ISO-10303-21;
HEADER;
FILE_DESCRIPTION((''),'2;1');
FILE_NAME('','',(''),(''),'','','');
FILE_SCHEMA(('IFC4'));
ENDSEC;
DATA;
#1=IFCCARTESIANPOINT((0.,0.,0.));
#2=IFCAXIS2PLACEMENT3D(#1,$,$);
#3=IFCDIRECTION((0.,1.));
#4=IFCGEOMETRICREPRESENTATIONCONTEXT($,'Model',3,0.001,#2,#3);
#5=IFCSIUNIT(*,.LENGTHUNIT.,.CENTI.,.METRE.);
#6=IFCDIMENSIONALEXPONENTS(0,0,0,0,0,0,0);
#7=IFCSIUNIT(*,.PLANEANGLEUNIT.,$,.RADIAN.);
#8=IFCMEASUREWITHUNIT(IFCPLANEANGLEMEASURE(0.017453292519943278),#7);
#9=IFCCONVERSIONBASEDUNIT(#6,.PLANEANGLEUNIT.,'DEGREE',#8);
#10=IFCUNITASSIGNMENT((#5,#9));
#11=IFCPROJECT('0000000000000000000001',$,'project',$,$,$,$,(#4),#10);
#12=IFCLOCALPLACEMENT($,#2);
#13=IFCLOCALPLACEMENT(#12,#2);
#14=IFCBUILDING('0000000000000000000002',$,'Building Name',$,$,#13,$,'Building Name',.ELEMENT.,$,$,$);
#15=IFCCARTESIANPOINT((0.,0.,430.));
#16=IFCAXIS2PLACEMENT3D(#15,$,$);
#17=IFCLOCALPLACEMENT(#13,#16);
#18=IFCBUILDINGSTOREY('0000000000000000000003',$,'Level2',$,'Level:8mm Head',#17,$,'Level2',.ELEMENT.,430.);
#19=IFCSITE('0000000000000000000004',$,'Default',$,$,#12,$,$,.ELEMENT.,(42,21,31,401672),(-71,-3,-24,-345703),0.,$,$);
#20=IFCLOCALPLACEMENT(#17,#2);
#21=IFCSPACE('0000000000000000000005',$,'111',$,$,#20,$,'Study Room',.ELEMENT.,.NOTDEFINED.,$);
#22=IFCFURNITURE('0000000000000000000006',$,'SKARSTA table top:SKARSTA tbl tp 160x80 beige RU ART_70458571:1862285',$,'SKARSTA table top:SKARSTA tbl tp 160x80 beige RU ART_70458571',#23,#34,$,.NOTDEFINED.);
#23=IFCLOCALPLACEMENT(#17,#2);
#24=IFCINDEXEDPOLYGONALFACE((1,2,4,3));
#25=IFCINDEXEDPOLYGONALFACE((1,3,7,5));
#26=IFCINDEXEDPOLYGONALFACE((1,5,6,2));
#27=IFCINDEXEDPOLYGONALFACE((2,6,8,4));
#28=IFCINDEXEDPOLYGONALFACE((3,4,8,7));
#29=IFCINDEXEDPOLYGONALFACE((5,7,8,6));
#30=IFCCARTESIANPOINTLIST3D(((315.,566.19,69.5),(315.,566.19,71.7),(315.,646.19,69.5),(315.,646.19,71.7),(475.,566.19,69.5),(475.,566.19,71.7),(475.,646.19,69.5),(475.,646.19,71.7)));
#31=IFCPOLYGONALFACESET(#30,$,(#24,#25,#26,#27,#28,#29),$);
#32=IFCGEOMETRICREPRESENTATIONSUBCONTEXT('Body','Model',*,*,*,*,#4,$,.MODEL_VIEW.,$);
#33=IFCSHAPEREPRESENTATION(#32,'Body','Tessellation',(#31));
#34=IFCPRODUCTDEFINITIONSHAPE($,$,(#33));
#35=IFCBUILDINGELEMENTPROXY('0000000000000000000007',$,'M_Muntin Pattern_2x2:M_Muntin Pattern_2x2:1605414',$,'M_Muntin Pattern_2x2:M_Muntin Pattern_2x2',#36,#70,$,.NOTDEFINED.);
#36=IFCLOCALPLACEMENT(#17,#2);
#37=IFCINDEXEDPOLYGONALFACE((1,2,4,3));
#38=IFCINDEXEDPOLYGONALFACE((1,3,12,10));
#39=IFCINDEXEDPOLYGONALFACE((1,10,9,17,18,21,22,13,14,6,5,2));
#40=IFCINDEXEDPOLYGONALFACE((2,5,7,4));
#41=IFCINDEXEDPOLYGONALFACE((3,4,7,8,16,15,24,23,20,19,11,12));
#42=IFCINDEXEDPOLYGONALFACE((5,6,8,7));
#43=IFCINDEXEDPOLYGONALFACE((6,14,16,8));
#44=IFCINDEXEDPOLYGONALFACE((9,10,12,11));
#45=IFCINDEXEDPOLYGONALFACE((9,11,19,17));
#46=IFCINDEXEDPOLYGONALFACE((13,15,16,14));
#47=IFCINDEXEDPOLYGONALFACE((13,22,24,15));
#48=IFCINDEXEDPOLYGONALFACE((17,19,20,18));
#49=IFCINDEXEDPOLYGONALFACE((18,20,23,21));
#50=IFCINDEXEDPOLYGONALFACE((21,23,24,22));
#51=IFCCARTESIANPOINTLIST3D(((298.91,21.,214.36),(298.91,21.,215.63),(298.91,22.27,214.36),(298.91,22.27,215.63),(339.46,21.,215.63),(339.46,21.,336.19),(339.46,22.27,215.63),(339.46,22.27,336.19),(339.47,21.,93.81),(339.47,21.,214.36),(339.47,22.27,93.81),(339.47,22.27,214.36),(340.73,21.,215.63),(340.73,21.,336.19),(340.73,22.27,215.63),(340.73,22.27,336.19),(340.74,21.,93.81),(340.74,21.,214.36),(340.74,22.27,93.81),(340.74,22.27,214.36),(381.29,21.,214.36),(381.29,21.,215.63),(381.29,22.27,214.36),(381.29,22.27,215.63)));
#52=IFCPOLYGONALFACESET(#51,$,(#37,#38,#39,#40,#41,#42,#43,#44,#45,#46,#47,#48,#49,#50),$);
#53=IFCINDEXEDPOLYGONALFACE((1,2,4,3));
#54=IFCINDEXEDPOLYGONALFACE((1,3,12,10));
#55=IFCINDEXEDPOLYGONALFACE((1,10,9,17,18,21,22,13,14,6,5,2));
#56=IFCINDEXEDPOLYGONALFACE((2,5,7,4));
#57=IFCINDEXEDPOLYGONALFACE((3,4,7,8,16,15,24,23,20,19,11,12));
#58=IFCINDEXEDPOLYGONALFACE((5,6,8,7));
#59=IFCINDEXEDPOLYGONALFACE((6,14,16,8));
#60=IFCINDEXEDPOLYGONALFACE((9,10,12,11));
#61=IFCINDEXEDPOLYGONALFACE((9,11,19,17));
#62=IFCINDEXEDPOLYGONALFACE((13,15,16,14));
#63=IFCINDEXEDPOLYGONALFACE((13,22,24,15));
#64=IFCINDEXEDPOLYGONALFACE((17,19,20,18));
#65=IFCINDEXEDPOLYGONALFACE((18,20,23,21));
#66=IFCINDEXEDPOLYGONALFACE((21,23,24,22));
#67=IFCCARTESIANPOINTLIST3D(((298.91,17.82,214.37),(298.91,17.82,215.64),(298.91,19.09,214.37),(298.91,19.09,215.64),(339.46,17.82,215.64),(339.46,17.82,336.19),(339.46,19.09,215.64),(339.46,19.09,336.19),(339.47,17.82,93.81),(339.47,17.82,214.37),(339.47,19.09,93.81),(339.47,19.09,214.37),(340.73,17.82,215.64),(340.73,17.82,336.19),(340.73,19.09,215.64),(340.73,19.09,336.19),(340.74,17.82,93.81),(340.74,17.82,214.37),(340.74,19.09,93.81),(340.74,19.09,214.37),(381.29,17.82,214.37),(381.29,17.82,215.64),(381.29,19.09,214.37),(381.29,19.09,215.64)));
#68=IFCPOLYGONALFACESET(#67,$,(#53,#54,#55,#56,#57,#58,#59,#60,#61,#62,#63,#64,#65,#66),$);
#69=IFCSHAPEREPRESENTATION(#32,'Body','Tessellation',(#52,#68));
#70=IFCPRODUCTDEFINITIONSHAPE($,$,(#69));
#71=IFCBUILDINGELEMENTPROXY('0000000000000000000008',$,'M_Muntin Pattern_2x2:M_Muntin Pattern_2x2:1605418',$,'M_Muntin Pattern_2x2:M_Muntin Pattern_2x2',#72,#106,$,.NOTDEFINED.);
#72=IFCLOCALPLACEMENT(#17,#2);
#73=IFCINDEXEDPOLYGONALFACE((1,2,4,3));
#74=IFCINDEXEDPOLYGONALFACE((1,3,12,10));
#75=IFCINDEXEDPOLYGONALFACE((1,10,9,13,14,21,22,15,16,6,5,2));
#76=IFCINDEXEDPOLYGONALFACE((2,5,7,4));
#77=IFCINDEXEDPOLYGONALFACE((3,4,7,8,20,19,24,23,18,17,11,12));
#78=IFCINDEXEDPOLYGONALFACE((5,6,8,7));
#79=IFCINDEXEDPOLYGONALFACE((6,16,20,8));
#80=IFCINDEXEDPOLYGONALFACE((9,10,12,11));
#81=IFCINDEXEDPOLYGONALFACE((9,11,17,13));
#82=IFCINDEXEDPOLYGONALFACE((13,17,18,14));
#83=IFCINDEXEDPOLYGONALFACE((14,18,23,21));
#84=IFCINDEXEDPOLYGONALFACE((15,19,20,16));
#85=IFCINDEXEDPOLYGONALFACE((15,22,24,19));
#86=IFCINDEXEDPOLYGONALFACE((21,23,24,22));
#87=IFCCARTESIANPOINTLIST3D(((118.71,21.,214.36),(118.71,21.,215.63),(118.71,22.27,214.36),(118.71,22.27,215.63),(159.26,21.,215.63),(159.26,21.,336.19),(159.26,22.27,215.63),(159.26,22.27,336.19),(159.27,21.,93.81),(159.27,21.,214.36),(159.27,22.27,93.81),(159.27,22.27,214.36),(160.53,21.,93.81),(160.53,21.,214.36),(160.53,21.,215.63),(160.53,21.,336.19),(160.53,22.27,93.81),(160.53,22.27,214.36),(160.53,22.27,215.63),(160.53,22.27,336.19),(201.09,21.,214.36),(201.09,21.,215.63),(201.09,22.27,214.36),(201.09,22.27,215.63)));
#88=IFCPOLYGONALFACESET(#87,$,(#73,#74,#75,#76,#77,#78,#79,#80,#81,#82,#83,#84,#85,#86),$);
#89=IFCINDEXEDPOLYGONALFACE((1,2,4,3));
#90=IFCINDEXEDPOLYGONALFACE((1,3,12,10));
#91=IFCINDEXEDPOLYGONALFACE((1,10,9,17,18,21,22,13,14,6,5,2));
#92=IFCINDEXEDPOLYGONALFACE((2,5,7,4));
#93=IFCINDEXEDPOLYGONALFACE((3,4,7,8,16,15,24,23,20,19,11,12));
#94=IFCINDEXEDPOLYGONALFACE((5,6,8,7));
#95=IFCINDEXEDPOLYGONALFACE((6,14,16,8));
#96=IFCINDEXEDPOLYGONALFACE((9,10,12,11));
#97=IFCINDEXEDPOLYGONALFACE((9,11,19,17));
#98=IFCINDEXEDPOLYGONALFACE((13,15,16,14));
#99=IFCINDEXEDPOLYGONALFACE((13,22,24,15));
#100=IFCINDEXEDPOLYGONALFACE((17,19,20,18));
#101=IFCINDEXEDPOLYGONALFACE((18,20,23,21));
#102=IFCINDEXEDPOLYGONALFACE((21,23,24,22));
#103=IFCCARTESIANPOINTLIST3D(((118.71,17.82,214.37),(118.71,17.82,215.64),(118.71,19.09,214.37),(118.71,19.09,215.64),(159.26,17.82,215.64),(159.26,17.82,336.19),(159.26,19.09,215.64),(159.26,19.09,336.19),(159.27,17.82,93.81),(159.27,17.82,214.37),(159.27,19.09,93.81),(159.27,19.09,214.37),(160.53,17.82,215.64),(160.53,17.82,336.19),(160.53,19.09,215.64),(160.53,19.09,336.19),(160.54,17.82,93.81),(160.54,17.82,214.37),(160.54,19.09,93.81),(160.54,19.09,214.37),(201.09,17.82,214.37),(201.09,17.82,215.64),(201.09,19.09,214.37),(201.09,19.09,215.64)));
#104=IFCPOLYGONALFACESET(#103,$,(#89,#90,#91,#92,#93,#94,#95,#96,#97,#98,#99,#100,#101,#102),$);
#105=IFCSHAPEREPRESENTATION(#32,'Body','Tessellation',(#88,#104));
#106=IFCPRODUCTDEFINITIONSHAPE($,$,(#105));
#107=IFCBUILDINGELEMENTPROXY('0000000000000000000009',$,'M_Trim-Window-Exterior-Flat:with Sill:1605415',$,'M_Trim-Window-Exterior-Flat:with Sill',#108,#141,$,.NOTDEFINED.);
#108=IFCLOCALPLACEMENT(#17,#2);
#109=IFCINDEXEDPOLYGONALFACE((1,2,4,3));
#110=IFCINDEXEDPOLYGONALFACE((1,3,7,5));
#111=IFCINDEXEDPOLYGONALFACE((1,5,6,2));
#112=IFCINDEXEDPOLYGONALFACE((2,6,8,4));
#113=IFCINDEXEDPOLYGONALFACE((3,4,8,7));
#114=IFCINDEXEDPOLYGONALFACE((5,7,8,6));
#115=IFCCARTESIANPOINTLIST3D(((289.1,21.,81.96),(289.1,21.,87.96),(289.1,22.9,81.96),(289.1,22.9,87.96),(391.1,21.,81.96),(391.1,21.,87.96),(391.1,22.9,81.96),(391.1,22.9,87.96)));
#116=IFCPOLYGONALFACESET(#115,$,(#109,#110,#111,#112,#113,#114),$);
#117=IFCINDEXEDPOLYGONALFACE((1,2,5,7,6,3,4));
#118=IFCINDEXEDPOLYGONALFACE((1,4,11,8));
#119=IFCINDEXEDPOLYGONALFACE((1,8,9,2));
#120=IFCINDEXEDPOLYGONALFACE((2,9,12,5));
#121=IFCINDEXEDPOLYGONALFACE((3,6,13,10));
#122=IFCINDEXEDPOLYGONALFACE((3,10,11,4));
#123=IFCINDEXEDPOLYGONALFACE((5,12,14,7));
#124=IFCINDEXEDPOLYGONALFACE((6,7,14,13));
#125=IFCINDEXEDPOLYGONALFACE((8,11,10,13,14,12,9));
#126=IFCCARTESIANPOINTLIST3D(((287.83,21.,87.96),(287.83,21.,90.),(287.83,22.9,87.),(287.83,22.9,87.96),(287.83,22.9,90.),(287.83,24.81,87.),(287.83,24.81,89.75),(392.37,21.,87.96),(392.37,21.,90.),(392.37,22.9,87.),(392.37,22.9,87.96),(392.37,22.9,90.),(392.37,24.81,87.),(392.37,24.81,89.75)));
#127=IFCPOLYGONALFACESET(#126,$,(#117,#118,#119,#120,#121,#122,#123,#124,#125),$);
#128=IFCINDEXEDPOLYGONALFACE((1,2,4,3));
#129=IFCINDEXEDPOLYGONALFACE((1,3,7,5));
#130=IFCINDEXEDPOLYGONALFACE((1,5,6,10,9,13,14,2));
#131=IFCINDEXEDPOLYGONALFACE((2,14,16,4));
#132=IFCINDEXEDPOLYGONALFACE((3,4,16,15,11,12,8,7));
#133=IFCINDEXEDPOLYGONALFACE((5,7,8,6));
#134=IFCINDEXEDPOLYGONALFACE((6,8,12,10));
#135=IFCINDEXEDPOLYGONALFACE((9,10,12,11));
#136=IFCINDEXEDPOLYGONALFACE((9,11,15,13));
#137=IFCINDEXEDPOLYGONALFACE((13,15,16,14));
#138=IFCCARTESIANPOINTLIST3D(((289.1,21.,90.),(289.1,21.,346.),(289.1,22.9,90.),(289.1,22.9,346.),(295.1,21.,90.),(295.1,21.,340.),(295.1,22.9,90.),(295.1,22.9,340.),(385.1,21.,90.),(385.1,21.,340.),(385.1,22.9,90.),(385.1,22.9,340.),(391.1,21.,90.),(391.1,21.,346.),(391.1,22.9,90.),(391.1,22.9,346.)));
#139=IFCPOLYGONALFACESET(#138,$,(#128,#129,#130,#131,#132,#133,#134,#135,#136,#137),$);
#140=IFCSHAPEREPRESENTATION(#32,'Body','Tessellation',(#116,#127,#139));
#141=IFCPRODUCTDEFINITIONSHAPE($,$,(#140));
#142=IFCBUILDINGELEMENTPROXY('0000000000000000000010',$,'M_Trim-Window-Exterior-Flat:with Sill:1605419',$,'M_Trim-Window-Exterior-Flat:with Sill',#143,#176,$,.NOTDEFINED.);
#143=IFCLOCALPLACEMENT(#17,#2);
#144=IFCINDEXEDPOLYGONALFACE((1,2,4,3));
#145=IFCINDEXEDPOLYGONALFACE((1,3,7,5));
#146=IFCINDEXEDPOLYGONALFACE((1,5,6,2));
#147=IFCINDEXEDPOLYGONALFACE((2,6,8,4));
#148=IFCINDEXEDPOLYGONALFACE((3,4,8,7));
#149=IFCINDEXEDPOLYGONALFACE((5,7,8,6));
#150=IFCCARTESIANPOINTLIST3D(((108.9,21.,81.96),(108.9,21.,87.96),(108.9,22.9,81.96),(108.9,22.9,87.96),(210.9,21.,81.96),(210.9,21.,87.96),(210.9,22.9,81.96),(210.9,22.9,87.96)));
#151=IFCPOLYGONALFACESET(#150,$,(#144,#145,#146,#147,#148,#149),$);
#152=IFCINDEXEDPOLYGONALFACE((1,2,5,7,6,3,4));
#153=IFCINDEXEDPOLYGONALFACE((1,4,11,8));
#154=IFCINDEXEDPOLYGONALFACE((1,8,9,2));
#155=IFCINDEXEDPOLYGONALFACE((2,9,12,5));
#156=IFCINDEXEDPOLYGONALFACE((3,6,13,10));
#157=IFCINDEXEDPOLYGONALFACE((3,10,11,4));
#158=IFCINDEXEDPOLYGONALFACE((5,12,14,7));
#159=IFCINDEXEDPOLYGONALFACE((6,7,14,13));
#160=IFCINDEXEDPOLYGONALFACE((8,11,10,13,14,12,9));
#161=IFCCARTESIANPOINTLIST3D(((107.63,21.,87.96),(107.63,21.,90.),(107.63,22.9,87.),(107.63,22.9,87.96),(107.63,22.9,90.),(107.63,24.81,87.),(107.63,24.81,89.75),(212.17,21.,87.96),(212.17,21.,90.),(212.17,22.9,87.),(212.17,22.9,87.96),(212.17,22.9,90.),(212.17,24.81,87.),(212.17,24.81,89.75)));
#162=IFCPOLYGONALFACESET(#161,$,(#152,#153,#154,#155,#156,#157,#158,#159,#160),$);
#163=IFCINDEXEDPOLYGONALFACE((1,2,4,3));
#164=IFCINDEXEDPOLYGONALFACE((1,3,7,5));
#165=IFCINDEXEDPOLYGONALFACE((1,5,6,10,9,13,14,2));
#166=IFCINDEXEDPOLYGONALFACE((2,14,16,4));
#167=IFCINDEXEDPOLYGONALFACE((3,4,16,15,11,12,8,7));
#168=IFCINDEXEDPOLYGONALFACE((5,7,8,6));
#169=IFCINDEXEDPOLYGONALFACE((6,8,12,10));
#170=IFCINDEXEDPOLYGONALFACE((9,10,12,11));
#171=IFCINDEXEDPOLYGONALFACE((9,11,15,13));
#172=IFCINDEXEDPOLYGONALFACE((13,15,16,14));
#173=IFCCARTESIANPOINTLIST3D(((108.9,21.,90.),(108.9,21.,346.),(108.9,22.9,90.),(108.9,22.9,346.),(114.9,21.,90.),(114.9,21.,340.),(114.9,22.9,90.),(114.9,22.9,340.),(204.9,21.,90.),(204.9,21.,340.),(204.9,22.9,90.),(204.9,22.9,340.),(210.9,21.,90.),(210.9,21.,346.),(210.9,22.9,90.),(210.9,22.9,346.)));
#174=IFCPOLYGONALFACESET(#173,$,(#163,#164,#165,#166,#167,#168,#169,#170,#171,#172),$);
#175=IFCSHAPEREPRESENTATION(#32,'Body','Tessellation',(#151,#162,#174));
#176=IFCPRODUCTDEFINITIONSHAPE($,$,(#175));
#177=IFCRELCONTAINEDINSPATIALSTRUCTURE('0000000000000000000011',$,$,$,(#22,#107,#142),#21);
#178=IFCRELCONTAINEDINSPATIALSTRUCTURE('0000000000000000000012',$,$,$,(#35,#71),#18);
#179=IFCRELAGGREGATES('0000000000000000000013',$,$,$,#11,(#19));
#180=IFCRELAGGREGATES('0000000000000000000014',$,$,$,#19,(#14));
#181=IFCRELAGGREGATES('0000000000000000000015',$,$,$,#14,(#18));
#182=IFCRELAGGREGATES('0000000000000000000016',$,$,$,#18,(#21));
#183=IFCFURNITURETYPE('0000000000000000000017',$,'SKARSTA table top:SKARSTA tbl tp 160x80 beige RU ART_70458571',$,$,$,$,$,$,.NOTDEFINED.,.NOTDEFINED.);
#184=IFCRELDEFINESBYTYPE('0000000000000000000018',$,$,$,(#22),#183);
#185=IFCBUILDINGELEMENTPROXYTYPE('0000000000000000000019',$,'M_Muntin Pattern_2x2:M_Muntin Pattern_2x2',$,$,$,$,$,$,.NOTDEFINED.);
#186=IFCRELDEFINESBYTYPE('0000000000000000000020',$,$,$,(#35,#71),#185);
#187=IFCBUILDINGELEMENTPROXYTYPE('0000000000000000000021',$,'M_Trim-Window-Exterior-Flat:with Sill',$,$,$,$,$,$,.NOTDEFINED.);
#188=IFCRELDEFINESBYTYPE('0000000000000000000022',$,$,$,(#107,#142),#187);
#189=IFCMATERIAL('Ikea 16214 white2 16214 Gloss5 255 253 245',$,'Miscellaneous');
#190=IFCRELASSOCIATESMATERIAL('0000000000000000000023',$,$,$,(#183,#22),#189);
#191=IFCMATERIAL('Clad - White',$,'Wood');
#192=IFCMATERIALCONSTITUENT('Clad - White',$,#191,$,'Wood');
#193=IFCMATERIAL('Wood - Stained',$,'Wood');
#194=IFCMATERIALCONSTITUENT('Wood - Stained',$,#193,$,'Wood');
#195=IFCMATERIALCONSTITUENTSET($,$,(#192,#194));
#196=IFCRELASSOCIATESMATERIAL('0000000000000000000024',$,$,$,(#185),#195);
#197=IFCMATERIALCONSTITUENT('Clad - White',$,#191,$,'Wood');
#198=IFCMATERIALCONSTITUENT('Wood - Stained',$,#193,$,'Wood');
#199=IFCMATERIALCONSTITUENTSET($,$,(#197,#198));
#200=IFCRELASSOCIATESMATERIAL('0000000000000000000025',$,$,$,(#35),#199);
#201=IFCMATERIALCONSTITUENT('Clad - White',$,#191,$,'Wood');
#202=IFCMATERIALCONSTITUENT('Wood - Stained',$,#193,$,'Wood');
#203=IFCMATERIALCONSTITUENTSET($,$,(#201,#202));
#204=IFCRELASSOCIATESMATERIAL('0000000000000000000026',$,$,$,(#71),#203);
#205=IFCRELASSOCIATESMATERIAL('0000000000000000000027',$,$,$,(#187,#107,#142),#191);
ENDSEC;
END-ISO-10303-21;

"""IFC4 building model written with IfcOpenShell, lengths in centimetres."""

from ifc_helpers import new_model, entity, si_unit, converted_unit, direction, frame, origin, place, context, subcontext, project, spatial, indexed_curve, outline, extrude, source, transform, mapped, material, constituent, constituent_set, type_object, type_shapes, element, save


model = new_model("IFC4")

# Units and contexts
model_context = context("Model", 3, precision=0.001, world=origin(), true_north=direction((0.0, 1.0)))
body_context = subcontext(model_context, "Body", "Model", "MODEL_VIEW")
ifc_project = project(units=[si_unit("LENGTHUNIT", "METRE", prefix="CENTI"), converted_unit("PLANEANGLEUNIT", "DEGREE", entity("IfcPlaneAngleMeasure", 0.017453292519943278), si_unit("PLANEANGLEUNIT", "RADIAN"), dimensions=[0, 0, 0, 0, 0, 0, 0])], contexts=[model_context])

# Site, building, storey
site_placement = place(None, origin())
site = spatial("IfcSite", under=ifc_project, at=site_placement, Name="Default", CompositionType="ELEMENT", RefLatitude=(42, 21, 31, 401672), RefLongitude=(-71, -3, -24, -345703), RefElevation=0.0)
building_placement = place(site_placement, origin())
building = spatial("IfcBuilding", under=site, at=building_placement, Name="Building Name", LongName="Building Name", CompositionType="ELEMENT")
storey_placement = place(building_placement, frame((0.0, 0.0, 430.0)))
storey = spatial("IfcBuildingStorey", under=building, at=storey_placement, Name="Level2", ObjectType="Level:8mm Head", LongName="Level2", CompositionType="ELEMENT", Elevation=430.0)

# Shared definitions
space_placement = place(storey_placement, origin())
space = spatial("IfcSpace", under=storey, at=space_placement, Name="111", LongName="Study Room", CompositionType="ELEMENT", PredefinedType="NOTDEFINED")

# Furniture
ifc_material_1 = material(Name="Ikea 16214 white2 16214 Gloss5 255 253 245", Category="Miscellaneous")
furniture_type = type_object("IfcFurnitureType", Name="SKARSTA table top:SKARSTA tbl tp 160x80 beige RU ART_70458571", AssemblyPlace="NOTDEFINED", PredefinedType="NOTDEFINED", material=ifc_material_1)
shared_shape_1 = source(origin(), body_context, "Body", "SweptSolid", [
    extrude(outline(indexed_curve([(-40.0, -80.0), (40.0, -80.0), (40.0, 80.0), (-40.0, 80.0), (-40.0, -80.0)], self_intersect=False)), frame((0.0, 0.0, 0.0), z_axis=(0.0, 0.0, 1.0), x_axis=(0.0, 1.0, 0.0)), (0.0, 0.0, 1.0), 2.2),
])
type_shapes(furniture_type, [shared_shape_1])
for number, where, z_axis, x_axis, name in (
    (1, (395.0, 606.19, 69.5), (0.0, 0.0, 1.0), (-1.0, 0.0, 0.0), "SKARSTA table top:SKARSTA tbl tp 160x80 beige RU ART_70458571:1862285"),
):
    element("IfcFurniture", number, at=place(space_placement, frame(where, z_axis=z_axis, x_axis=x_axis)), inside=space, type_object=furniture_type, material=ifc_material_1, Name=name, ObjectType="SKARSTA table top:SKARSTA tbl tp 160x80 beige RU ART_70458571", PredefinedType="NOTDEFINED", context=body_context, shape_type="MappedRepresentation", body=[
        mapped(shared_shape_1, transform((0.0, 0.0, 0.0), scale=1.0)),
    ])

# Building element proxies
ifc_material_2 = material(Name="Clad - White", Category="Wood")
ifc_constituent_1 = constituent(ifc_material_2, Name="Clad - White", Category="Wood")
ifc_material_3 = material(Name="Wood - Stained", Category="Wood")
ifc_constituent_2 = constituent(ifc_material_3, Name="Wood - Stained", Category="Wood")
ifc_constituent_set_1 = constituent_set(constituents=[ifc_constituent_1, ifc_constituent_2])
ifc_constituent_3 = constituent(ifc_material_2, Name="Clad - White", Category="Wood")
ifc_constituent_4 = constituent(ifc_material_3, Name="Wood - Stained", Category="Wood")
ifc_constituent_set_2 = constituent_set(constituents=[ifc_constituent_3, ifc_constituent_4])
building_element_proxy_type_1 = type_object("IfcBuildingElementProxyType", Name="M_Muntin Pattern_2x2:M_Muntin Pattern_2x2", PredefinedType="NOTDEFINED", material=ifc_constituent_set_2)
shared_shape_2 = source(origin(), body_context, "Body", "SweptSolid", [
    extrude(outline(indexed_curve([(0.64, -0.64), (121.19, -0.64), (121.19, 0.63), (0.64, 0.63), (0.64, 41.19), (-0.63, 41.19), (-0.63, 0.63), (-121.19, 0.63), (-121.19, -0.64), (-0.63, -0.64), (-0.63, -41.19), (0.64, -41.19), (0.64, -0.64)], self_intersect=False)), frame((0.0, 0.95, 121.19), z_axis=(0.0, 1.0, 0.0), x_axis=(0.0, 0.0, 1.0)), (0.0, 0.0, 1.0), 1.27),
    extrude(outline(indexed_curve([(0.64, -0.64), (121.19, -0.64), (121.19, 0.63), (0.64, 0.63), (0.64, 41.19), (-0.63, 41.19), (-0.63, 0.63), (-121.19, 0.63), (-121.19, -0.64), (-0.63, -0.64), (-0.63, -41.19), (0.64, -41.19), (0.64, -0.64)], self_intersect=False)), frame((0.0, -2.22, 121.19), z_axis=(0.0, 1.0, 0.0), x_axis=(0.0, 0.0, 1.0)), (0.0, 0.0, 1.0), 1.27),
])
type_shapes(building_element_proxy_type_1, [shared_shape_2])
proxy_1_placement = place(storey_placement, frame((340.1, 20.05, 93.81)))
element("IfcBuildingElementProxy", 2, at=proxy_1_placement, inside=storey, type_object=building_element_proxy_type_1, material=ifc_constituent_set_1, Name="M_Muntin Pattern_2x2:M_Muntin Pattern_2x2:1605414", ObjectType="M_Muntin Pattern_2x2:M_Muntin Pattern_2x2", PredefinedType="NOTDEFINED", context=body_context, shape_type="MappedRepresentation", body=[
    mapped(shared_shape_2, transform((0.0, 0.0, 0.0), scale=1.0)),
])
ifc_constituent_5 = constituent(ifc_material_2, Name="Clad - White", Category="Wood")
ifc_constituent_6 = constituent(ifc_material_3, Name="Wood - Stained", Category="Wood")
ifc_constituent_set_3 = constituent_set(constituents=[ifc_constituent_5, ifc_constituent_6])
proxy_2_placement = place(storey_placement, frame((159.9, 20.05, 93.81)))
element("IfcBuildingElementProxy", 3, at=proxy_2_placement, inside=storey, type_object=building_element_proxy_type_1, material=ifc_constituent_set_3, Name="M_Muntin Pattern_2x2:M_Muntin Pattern_2x2:1605418", ObjectType="M_Muntin Pattern_2x2:M_Muntin Pattern_2x2", PredefinedType="NOTDEFINED", context=body_context, shape_type="MappedRepresentation", body=[
    mapped(shared_shape_2, transform((0.0, 0.0, 0.0), scale=1.0)),
])
building_element_proxy_type_2 = type_object("IfcBuildingElementProxyType", Name="M_Trim-Window-Exterior-Flat:with Sill", PredefinedType="NOTDEFINED", material=ifc_material_2)
shared_shape_3 = source(origin(), body_context, "Body", "SweptSolid", [
    extrude(outline(indexed_curve([(-3.0, -51.0), (3.0, -51.0), (3.0, 51.0), (-3.0, 51.0), (-3.0, -51.0)], self_intersect=False)), frame((0.0, 255.04, 0.0), z_axis=(0.0, 0.0, 1.0), x_axis=(0.0, 1.0, 0.0)), (0.0, 0.0, 1.0), 1.9),
    extrude(outline(indexed_curve([(-1.52, -1.9), (1.23, -1.9), (1.48, 0.0), (1.48, 1.9), (-0.57, 1.9), (-0.57, 0.0), (-1.52, 0.0), (-1.52, -1.9)], self_intersect=False)), frame((-52.27, 251.48, 1.9), z_axis=(1.0, 0.0, 0.0), x_axis=(0.0, -1.0, 0.0)), (0.0, 0.0, 1.0), 104.54),
    extrude(outline(indexed_curve([(-51.0, -129.5), (51.0, -129.5), (51.0, 126.5), (45.0, 126.5), (45.0, -123.5), (-45.0, -123.5), (-45.0, 126.5), (-51.0, 126.5), (-51.0, -129.5)], self_intersect=False)), frame((0.0, 123.5, 0.0)), (0.0, 0.0, 1.0), 1.9),
])
type_shapes(building_element_proxy_type_2, [shared_shape_3])
for number, where, z_axis, x_axis, name in (
    (4, (340.1, 21.0, 340.0), (0.0, 1.0, 0.0), (1.0, 0.0, 0.0), "M_Trim-Window-Exterior-Flat:with Sill:1605415"),
    (5, (159.9, 21.0, 340.0), (0.0, 1.0, 0.0), (1.0, 0.0, 0.0), "M_Trim-Window-Exterior-Flat:with Sill:1605419"),
):
    element("IfcBuildingElementProxy", number, at=place(space_placement, frame(where, z_axis=z_axis, x_axis=x_axis)), inside=space, type_object=building_element_proxy_type_2, material=ifc_material_2, Name=name, ObjectType="M_Trim-Window-Exterior-Flat:with Sill", PredefinedType="NOTDEFINED", context=body_context, shape_type="MappedRepresentation", body=[
        mapped(shared_shape_3, transform((0.0, 0.0, 0.0), scale=1.0)),
    ])

save(model, "model.ifc")
